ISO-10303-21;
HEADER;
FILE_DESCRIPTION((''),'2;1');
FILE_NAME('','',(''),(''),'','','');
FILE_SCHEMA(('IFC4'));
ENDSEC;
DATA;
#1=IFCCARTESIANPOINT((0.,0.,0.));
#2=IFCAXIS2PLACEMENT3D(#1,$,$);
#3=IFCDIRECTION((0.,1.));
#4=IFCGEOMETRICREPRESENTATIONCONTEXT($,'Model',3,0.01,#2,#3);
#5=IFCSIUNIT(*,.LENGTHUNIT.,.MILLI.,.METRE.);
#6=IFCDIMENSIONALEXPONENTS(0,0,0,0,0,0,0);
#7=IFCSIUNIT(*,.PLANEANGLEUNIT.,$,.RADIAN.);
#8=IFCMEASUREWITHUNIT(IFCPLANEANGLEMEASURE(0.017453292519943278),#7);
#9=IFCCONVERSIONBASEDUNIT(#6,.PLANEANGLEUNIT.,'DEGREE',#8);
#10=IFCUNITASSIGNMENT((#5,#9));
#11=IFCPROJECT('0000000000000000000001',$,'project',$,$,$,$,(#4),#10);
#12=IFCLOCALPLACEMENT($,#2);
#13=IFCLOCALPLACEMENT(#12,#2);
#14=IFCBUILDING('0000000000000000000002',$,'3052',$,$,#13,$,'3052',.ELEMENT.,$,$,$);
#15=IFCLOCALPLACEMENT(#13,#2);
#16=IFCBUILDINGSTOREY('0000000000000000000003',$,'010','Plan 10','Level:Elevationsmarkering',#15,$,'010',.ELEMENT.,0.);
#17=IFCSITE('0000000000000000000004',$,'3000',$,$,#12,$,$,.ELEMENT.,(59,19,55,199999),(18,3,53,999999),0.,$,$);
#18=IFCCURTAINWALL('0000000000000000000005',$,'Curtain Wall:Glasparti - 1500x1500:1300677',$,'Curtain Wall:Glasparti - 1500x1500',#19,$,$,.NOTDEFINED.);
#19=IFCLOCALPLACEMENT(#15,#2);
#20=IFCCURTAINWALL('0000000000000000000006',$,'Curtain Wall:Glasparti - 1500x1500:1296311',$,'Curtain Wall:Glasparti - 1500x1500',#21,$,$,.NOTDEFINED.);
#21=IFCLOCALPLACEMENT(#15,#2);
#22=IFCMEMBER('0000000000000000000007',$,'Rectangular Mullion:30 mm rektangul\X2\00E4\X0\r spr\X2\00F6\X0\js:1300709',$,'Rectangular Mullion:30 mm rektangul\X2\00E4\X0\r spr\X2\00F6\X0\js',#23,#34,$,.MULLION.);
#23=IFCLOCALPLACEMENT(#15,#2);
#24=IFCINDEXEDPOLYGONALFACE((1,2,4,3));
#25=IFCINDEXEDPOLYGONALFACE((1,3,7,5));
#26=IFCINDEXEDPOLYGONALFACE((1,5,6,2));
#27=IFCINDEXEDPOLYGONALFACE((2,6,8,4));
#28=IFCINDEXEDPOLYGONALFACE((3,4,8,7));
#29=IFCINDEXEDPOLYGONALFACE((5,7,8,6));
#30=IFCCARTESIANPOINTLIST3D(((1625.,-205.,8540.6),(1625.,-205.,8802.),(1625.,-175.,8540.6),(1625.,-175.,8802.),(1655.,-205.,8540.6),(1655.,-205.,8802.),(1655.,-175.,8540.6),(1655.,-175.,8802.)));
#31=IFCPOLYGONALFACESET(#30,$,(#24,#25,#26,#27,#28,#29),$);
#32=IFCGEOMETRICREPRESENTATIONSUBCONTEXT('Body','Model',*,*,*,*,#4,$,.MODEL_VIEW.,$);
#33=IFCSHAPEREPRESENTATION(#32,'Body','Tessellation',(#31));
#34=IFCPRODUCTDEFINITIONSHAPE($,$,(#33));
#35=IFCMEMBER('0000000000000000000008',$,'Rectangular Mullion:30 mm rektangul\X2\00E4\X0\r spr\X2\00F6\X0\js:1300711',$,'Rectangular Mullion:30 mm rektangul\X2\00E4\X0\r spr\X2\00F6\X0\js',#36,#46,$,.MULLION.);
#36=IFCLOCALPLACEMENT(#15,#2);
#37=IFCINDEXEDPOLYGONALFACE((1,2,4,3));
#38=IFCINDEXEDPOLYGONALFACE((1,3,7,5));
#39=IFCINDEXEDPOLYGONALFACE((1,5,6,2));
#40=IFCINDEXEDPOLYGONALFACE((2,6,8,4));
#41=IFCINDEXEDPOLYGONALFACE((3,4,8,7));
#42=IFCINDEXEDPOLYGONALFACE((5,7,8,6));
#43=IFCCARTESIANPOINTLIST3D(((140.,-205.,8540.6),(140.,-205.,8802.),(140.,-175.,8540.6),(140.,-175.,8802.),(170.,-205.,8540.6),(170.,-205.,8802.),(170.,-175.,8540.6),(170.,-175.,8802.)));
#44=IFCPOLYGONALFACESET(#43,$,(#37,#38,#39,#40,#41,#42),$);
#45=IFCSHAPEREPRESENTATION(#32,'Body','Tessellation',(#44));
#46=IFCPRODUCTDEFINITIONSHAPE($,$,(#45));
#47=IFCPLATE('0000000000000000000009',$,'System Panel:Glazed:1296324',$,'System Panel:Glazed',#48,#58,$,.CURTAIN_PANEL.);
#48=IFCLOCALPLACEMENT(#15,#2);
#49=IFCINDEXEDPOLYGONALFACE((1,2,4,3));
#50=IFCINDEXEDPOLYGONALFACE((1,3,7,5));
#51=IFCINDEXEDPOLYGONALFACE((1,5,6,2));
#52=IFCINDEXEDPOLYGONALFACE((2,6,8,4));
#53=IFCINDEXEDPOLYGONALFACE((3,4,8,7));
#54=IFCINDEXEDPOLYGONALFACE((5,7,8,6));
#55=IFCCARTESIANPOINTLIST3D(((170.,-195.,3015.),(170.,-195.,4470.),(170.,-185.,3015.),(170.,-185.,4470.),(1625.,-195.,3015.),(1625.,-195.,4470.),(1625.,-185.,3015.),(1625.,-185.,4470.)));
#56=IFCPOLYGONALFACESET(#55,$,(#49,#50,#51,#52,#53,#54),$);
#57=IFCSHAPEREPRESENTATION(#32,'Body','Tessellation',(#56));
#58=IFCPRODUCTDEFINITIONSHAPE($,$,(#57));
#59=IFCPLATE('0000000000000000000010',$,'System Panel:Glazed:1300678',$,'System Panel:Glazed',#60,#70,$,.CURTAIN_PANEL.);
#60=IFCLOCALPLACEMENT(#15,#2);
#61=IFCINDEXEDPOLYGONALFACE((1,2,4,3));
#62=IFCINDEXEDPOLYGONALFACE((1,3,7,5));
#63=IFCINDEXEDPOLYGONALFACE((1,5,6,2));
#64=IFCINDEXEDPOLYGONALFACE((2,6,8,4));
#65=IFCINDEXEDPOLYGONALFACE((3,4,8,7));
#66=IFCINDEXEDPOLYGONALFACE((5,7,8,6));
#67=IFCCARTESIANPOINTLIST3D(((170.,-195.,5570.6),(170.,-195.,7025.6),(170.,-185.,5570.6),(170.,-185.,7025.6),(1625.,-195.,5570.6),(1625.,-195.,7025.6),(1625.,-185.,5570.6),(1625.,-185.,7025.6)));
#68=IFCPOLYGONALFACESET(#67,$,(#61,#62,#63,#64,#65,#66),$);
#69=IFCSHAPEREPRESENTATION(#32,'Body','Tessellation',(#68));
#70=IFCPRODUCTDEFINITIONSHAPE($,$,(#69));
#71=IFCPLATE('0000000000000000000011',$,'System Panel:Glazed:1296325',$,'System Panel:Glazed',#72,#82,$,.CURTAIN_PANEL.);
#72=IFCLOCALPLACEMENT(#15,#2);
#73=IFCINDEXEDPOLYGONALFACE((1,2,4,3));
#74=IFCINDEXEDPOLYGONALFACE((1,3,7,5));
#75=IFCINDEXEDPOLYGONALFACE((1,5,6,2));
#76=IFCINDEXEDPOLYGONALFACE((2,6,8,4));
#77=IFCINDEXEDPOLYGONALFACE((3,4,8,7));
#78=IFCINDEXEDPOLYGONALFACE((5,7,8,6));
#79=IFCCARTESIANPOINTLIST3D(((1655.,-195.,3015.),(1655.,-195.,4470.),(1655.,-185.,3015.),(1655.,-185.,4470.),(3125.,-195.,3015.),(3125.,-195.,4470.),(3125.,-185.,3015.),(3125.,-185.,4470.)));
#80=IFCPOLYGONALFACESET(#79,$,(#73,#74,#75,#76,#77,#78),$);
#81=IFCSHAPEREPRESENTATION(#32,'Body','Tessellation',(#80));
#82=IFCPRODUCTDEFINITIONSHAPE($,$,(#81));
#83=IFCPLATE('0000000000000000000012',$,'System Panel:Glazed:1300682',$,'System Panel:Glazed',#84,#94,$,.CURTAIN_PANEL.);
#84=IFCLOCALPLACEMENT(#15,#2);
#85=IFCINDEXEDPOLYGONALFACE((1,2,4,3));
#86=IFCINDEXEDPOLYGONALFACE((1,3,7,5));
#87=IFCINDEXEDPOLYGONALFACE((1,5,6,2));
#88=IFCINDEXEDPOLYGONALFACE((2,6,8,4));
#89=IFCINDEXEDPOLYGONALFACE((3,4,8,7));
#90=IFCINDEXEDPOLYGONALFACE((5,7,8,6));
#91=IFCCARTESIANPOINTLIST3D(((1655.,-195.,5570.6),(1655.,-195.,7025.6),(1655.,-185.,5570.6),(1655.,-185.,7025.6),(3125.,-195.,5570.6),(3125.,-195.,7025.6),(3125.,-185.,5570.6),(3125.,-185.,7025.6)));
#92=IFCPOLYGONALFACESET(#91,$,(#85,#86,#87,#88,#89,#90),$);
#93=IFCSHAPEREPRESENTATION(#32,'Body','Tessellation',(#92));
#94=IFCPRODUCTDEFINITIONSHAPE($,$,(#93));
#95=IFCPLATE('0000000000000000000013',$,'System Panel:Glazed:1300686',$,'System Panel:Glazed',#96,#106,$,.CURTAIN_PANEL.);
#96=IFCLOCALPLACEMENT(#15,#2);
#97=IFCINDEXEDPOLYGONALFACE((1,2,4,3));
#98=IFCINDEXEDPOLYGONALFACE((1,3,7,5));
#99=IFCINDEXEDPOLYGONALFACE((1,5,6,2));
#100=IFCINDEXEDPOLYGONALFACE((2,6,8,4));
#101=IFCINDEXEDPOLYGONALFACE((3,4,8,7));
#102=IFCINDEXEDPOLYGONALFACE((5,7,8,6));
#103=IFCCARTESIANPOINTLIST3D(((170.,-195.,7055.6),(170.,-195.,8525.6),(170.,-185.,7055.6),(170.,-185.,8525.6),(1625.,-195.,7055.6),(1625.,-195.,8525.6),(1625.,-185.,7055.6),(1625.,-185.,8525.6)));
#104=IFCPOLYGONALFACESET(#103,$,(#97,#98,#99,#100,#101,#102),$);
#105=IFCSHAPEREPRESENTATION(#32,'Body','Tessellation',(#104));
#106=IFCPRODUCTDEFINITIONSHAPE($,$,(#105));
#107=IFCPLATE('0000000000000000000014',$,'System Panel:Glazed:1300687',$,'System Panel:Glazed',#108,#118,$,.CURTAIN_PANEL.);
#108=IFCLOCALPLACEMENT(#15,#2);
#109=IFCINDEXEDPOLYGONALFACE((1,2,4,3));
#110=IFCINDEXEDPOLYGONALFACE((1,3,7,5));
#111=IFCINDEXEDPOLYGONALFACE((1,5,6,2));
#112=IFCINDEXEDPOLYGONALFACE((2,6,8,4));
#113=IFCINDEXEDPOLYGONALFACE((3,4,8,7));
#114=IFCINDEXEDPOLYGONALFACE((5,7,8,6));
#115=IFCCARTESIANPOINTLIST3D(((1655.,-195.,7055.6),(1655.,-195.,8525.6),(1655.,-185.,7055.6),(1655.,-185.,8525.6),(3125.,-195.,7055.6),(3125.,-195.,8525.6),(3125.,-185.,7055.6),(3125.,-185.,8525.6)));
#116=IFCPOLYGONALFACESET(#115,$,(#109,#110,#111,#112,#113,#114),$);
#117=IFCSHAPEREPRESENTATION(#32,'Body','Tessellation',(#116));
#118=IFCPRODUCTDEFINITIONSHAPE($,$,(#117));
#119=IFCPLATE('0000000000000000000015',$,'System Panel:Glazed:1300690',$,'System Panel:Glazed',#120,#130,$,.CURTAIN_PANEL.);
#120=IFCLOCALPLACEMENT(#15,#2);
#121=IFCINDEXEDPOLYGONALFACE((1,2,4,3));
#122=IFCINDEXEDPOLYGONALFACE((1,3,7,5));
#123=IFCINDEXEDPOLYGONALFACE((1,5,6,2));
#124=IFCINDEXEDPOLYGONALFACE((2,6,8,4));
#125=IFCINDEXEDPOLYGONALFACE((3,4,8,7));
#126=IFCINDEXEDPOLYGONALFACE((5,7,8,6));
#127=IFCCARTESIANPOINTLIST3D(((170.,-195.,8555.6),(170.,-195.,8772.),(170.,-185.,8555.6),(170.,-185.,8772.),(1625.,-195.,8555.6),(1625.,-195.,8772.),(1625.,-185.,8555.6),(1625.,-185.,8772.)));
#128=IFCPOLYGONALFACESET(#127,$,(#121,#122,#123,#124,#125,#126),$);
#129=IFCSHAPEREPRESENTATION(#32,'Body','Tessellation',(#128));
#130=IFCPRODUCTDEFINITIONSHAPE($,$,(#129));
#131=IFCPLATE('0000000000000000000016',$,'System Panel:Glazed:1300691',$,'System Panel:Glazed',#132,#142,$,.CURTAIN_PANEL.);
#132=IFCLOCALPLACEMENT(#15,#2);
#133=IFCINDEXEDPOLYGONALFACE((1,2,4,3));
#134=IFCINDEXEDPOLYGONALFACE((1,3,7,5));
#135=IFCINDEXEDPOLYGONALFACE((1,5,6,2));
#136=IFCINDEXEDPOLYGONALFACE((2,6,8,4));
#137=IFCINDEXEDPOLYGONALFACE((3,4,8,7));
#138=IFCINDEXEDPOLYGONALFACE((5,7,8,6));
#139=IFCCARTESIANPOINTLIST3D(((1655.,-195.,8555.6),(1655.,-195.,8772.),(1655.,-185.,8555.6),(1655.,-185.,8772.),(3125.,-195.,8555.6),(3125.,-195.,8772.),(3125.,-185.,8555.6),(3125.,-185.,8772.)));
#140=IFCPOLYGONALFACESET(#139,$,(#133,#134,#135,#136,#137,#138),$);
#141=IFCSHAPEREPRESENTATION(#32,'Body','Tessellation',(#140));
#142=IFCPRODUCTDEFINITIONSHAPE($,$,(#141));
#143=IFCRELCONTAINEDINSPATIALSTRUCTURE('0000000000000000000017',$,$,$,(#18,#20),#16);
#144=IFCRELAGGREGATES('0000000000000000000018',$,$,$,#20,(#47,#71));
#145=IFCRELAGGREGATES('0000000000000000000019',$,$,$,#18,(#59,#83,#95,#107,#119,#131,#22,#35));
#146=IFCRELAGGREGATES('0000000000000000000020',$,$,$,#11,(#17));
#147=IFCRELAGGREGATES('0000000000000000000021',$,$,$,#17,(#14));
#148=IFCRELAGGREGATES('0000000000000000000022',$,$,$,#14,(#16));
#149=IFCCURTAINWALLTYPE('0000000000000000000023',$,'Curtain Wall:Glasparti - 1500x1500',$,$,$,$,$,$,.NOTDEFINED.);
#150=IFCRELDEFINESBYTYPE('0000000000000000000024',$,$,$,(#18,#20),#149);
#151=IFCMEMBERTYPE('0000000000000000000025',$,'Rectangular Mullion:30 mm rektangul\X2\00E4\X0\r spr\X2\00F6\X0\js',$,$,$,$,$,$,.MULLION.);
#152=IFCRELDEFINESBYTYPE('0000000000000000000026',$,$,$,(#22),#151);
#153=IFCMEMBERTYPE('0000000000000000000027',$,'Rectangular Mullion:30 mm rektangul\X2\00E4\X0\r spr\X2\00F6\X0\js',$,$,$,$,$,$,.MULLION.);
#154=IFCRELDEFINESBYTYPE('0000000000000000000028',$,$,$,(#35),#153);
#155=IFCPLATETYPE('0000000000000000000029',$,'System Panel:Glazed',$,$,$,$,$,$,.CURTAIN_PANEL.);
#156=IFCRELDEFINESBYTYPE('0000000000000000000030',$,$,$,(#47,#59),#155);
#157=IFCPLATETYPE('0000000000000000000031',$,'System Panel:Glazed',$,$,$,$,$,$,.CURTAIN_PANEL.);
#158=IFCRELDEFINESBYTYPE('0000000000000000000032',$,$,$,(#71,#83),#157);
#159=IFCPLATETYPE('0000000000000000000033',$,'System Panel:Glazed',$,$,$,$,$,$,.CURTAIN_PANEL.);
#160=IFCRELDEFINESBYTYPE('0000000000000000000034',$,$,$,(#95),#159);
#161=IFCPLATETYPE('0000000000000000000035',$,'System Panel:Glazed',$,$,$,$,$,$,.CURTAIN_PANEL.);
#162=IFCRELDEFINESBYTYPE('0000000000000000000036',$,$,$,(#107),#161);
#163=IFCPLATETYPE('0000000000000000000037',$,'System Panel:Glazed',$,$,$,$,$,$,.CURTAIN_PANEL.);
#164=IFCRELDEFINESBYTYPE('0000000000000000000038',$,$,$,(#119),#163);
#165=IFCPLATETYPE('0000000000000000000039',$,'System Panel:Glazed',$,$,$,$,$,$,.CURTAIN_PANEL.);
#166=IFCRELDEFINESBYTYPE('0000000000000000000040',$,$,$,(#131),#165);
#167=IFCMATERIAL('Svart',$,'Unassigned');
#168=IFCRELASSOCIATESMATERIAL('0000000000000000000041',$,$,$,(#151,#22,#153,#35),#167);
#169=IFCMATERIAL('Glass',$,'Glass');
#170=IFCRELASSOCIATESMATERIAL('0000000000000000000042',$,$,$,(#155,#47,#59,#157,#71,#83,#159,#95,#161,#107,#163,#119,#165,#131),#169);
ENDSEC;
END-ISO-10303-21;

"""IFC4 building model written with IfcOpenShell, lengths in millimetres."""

from ifc_helpers import new_model, entity, si_unit, converted_unit, direction, frame, origin, place, context, subcontext, project, spatial, indexed_curve, outline, extrude, source, transform, mapped, material, type_object, type_shapes, element, aggregate, save


model = new_model("IFC4")

# Units and contexts
model_context = context("Model", 3, precision=0.01, world=origin(), true_north=direction((0.0, 1.0)))
body_context = subcontext(model_context, "Body", "Model", "MODEL_VIEW")
ifc_project = project(units=[si_unit("LENGTHUNIT", "METRE", prefix="MILLI"), converted_unit("PLANEANGLEUNIT", "DEGREE", entity("IfcPlaneAngleMeasure", 0.017453292519943278), si_unit("PLANEANGLEUNIT", "RADIAN"), dimensions=[0, 0, 0, 0, 0, 0, 0])], contexts=[model_context])

# Site, building, storey
site_placement = place(None, origin())
site = spatial("IfcSite", under=ifc_project, at=site_placement, Name="3000", CompositionType="ELEMENT", RefLatitude=(59, 19, 55, 199999), RefLongitude=(18, 3, 53, 999999), RefElevation=0.0)
building_placement = place(site_placement, origin())
building = spatial("IfcBuilding", under=site, at=building_placement, Name="3052", LongName="3052", CompositionType="ELEMENT")
storey_placement = place(building_placement, origin())
storey = spatial("IfcBuildingStorey", under=building, at=storey_placement, Name="010", Description="Plan 10", ObjectType="Level:Elevationsmarkering", LongName="010", CompositionType="ELEMENT", Elevation=0.0)

# Curtain wall
curtain_wall_type = type_object("IfcCurtainWallType", Name="Curtain Wall:Glasparti - 1500x1500", PredefinedType="NOTDEFINED")
curtain_wall_1_placement = place(storey_placement, origin())
curtain_wall_1 = element("IfcCurtainWall", 1, at=curtain_wall_1_placement, inside=storey, type_object=curtain_wall_type, Name="Curtain Wall:Glasparti - 1500x1500:1300677", ObjectType="Curtain Wall:Glasparti - 1500x1500", PredefinedType="NOTDEFINED")
ifc_material_1 = material(Name="Svart", Category="Unassigned")

# Curtain wall
curtain_wall_2_placement = place(storey_placement, origin())
curtain_wall_2 = element("IfcCurtainWall", 2, at=curtain_wall_2_placement, inside=storey, type_object=curtain_wall_type, Name="Curtain Wall:Glasparti - 1500x1500:1296311", ObjectType="Curtain Wall:Glasparti - 1500x1500", PredefinedType="NOTDEFINED")

# Members
member_type_1 = type_object("IfcMemberType", Name="Rectangular Mullion:30 mm rektangulär spröjs", PredefinedType="MULLION", material=ifc_material_1)
shared_shape_1 = source(origin(), body_context, "Body", "SweptSolid", [
    extrude(outline(indexed_curve([(-15.0, -15.0), (15.0, -15.0), (15.0, 15.0), (-15.0, 15.0), (-15.0, -15.0)], self_intersect=False)), frame((0.0, 0.0, -261.4), z_axis=(0.0, 0.0, 1.0), x_axis=(-1.0, 0.0, 0.0)), (0.0, 0.0, 1.0), 261.4),
])
type_shapes(member_type_1, [shared_shape_1])
member_1_placement = place(curtain_wall_1_placement, frame((1640.0, -190.0, 8540.6), z_axis=(0.0, 0.0, -1.0), x_axis=(1.0, 0.0, 0.0)))
member_1 = element("IfcMember", 3, at=member_1_placement, type_object=member_type_1, material=ifc_material_1, Name="Rectangular Mullion:30 mm rektangulär spröjs:1300709", ObjectType="Rectangular Mullion:30 mm rektangulär spröjs", PredefinedType="MULLION", context=body_context, shape_type="MappedRepresentation", body=[
    mapped(shared_shape_1, transform((0.0, 0.0, 0.0), scale=1.0)),
])
member_type_2 = type_object("IfcMemberType", Name="Rectangular Mullion:30 mm rektangulär spröjs", PredefinedType="MULLION", material=ifc_material_1)
shared_shape_2 = source(origin(), body_context, "Body", "SweptSolid", [
    extrude(outline(indexed_curve([(-15.0, -15.0), (15.0, -15.0), (15.0, 15.0), (-15.0, 15.0), (-15.0, -15.0)], self_intersect=False)), frame((-15.0, 0.0, -261.4), z_axis=(0.0, 0.0, 1.0), x_axis=(-1.0, 0.0, 0.0)), (0.0, 0.0, 1.0), 261.4),
])
type_shapes(member_type_2, [shared_shape_2])
member_2_placement = place(curtain_wall_1_placement, frame((140.0, -190.0, 8802.0), z_axis=(0.0, 0.0, 1.0), x_axis=(-1.0, 0.0, 0.0)))
member_2 = element("IfcMember", 4, at=member_2_placement, type_object=member_type_2, material=ifc_material_1, Name="Rectangular Mullion:30 mm rektangulär spröjs:1300711", ObjectType="Rectangular Mullion:30 mm rektangulär spröjs", PredefinedType="MULLION", context=body_context, shape_type="MappedRepresentation", body=[
    mapped(shared_shape_2, transform((0.0, 0.0, 0.0), scale=1.0)),
])

# Plates
ifc_material_2 = material(Name="Glass", Category="Glass")
plate_type_1 = type_object("IfcPlateType", Name="System Panel:Glazed", PredefinedType="CURTAIN_PANEL", material=ifc_material_2)
shared_shape_3 = source(origin(), body_context, "Body", "SweptSolid", [
    extrude(outline(indexed_curve([(-5.0, -727.5), (5.0, -727.5), (5.0, 727.5), (-5.0, 727.5), (-5.0, -727.5)], self_intersect=False)), frame((0.0, 0.0, 0.0), z_axis=(0.0, 0.0, 1.0), x_axis=(0.0, 1.0, 0.0)), (0.0, 0.0, 1.0), 1455.0),
])
type_shapes(plate_type_1, [shared_shape_3])
plate_1_placement = place(curtain_wall_2_placement, frame((897.5, -190.0, 3015.0)))
plate_1 = element("IfcPlate", 5, at=plate_1_placement, type_object=plate_type_1, material=ifc_material_2, Name="System Panel:Glazed:1296324", ObjectType="System Panel:Glazed", PredefinedType="CURTAIN_PANEL", context=body_context, shape_type="MappedRepresentation", body=[
    mapped(shared_shape_3, transform((0.0, 0.0, 0.0), scale=1.0)),
])
plate_2_placement = place(curtain_wall_1_placement, frame((897.5, -190.0, 5570.6)))
plate_2 = element("IfcPlate", 6, at=plate_2_placement, type_object=plate_type_1, material=ifc_material_2, Name="System Panel:Glazed:1300678", ObjectType="System Panel:Glazed", PredefinedType="CURTAIN_PANEL", context=body_context, shape_type="MappedRepresentation", body=[
    mapped(shared_shape_3, transform((0.0, 0.0, 0.0), scale=1.0)),
])
plate_type_2 = type_object("IfcPlateType", Name="System Panel:Glazed", PredefinedType="CURTAIN_PANEL", material=ifc_material_2)
shared_shape_4 = source(origin(), body_context, "Body", "SweptSolid", [
    extrude(outline(indexed_curve([(-5.0, -735.0), (5.0, -735.0), (5.0, 735.0), (-5.0, 735.0), (-5.0, -735.0)], self_intersect=False)), frame((0.0, 0.0, 0.0), z_axis=(0.0, 0.0, 1.0), x_axis=(0.0, 1.0, 0.0)), (0.0, 0.0, 1.0), 1455.0),
])
type_shapes(plate_type_2, [shared_shape_4])
plate_3_placement = place(curtain_wall_2_placement, frame((2390.0, -190.0, 3015.0)))
plate_3 = element("IfcPlate", 7, at=plate_3_placement, type_object=plate_type_2, material=ifc_material_2, Name="System Panel:Glazed:1296325", ObjectType="System Panel:Glazed", PredefinedType="CURTAIN_PANEL", context=body_context, shape_type="MappedRepresentation", body=[
    mapped(shared_shape_4, transform((0.0, 0.0, 0.0), scale=1.0)),
])
aggregate(curtain_wall_2, [plate_1, plate_3])
plate_4_placement = place(curtain_wall_1_placement, frame((2390.0, -190.0, 5570.6)))
plate_4 = element("IfcPlate", 8, at=plate_4_placement, type_object=plate_type_2, material=ifc_material_2, Name="System Panel:Glazed:1300682", ObjectType="System Panel:Glazed", PredefinedType="CURTAIN_PANEL", context=body_context, shape_type="MappedRepresentation", body=[
    mapped(shared_shape_4, transform((0.0, 0.0, 0.0), scale=1.0)),
])
plate_type_3 = type_object("IfcPlateType", Name="System Panel:Glazed", PredefinedType="CURTAIN_PANEL", material=ifc_material_2)
shared_shape_5 = source(origin(), body_context, "Body", "SweptSolid", [
    extrude(outline(indexed_curve([(-5.0, -727.5), (5.0, -727.5), (5.0, 727.5), (-5.0, 727.5), (-5.0, -727.5)], self_intersect=False)), frame((0.0, 0.0, 0.0), z_axis=(0.0, 0.0, 1.0), x_axis=(0.0, 1.0, 0.0)), (0.0, 0.0, 1.0), 1470.0),
])
type_shapes(plate_type_3, [shared_shape_5])
plate_5_placement = place(curtain_wall_1_placement, frame((897.5, -190.0, 7055.6)))
plate_5 = element("IfcPlate", 9, at=plate_5_placement, type_object=plate_type_3, material=ifc_material_2, Name="System Panel:Glazed:1300686", ObjectType="System Panel:Glazed", PredefinedType="CURTAIN_PANEL", context=body_context, shape_type="MappedRepresentation", body=[
    mapped(shared_shape_5, transform((0.0, 0.0, 0.0), scale=1.0)),
])
plate_type_4 = type_object("IfcPlateType", Name="System Panel:Glazed", PredefinedType="CURTAIN_PANEL", material=ifc_material_2)
shared_shape_6 = source(origin(), body_context, "Body", "SweptSolid", [
    extrude(outline(indexed_curve([(-5.0, -735.0), (5.0, -735.0), (5.0, 735.0), (-5.0, 735.0), (-5.0, -735.0)], self_intersect=False)), frame((0.0, 0.0, 0.0), z_axis=(0.0, 0.0, 1.0), x_axis=(0.0, 1.0, 0.0)), (0.0, 0.0, 1.0), 1470.0),
])
type_shapes(plate_type_4, [shared_shape_6])
plate_6_placement = place(curtain_wall_1_placement, frame((2390.0, -190.0, 7055.6)))
plate_6 = element("IfcPlate", 10, at=plate_6_placement, type_object=plate_type_4, material=ifc_material_2, Name="System Panel:Glazed:1300687", ObjectType="System Panel:Glazed", PredefinedType="CURTAIN_PANEL", context=body_context, shape_type="MappedRepresentation", body=[
    mapped(shared_shape_6, transform((0.0, 0.0, 0.0), scale=1.0)),
])
plate_type_5 = type_object("IfcPlateType", Name="System Panel:Glazed", PredefinedType="CURTAIN_PANEL", material=ifc_material_2)
shared_shape_7 = source(origin(), body_context, "Body", "SweptSolid", [
    extrude(outline(indexed_curve([(-5.0, -727.5), (5.0, -727.5), (5.0, 727.5), (-5.0, 727.5), (-5.0, -727.5)], self_intersect=False)), frame((0.0, 0.0, 0.0), z_axis=(0.0, 0.0, 1.0), x_axis=(0.0, 1.0, 0.0)), (0.0, 0.0, 1.0), 216.4),
])
type_shapes(plate_type_5, [shared_shape_7])
plate_7_placement = place(curtain_wall_1_placement, frame((897.5, -190.0, 8555.6)))
plate_7 = element("IfcPlate", 11, at=plate_7_placement, type_object=plate_type_5, material=ifc_material_2, Name="System Panel:Glazed:1300690", ObjectType="System Panel:Glazed", PredefinedType="CURTAIN_PANEL", context=body_context, shape_type="MappedRepresentation", body=[
    mapped(shared_shape_7, transform((0.0, 0.0, 0.0), scale=1.0)),
])
plate_type_6 = type_object("IfcPlateType", Name="System Panel:Glazed", PredefinedType="CURTAIN_PANEL", material=ifc_material_2)
shared_shape_8 = source(origin(), body_context, "Body", "SweptSolid", [
    extrude(outline(indexed_curve([(-5.0, -735.0), (5.0, -735.0), (5.0, 735.0), (-5.0, 735.0), (-5.0, -735.0)], self_intersect=False)), frame((0.0, 0.0, 0.0), z_axis=(0.0, 0.0, 1.0), x_axis=(0.0, 1.0, 0.0)), (0.0, 0.0, 1.0), 216.4),
])
type_shapes(plate_type_6, [shared_shape_8])
plate_8_placement = place(curtain_wall_1_placement, frame((2390.0, -190.0, 8555.6)))
plate_8 = element("IfcPlate", 12, at=plate_8_placement, type_object=plate_type_6, material=ifc_material_2, Name="System Panel:Glazed:1300691", ObjectType="System Panel:Glazed", PredefinedType="CURTAIN_PANEL", context=body_context, shape_type="MappedRepresentation", body=[
    mapped(shared_shape_8, transform((0.0, 0.0, 0.0), scale=1.0)),
])
aggregate(curtain_wall_1, [plate_2, plate_4, plate_5, plate_6, plate_7, plate_8, member_1, member_2])

save(model, "model.ifc")
